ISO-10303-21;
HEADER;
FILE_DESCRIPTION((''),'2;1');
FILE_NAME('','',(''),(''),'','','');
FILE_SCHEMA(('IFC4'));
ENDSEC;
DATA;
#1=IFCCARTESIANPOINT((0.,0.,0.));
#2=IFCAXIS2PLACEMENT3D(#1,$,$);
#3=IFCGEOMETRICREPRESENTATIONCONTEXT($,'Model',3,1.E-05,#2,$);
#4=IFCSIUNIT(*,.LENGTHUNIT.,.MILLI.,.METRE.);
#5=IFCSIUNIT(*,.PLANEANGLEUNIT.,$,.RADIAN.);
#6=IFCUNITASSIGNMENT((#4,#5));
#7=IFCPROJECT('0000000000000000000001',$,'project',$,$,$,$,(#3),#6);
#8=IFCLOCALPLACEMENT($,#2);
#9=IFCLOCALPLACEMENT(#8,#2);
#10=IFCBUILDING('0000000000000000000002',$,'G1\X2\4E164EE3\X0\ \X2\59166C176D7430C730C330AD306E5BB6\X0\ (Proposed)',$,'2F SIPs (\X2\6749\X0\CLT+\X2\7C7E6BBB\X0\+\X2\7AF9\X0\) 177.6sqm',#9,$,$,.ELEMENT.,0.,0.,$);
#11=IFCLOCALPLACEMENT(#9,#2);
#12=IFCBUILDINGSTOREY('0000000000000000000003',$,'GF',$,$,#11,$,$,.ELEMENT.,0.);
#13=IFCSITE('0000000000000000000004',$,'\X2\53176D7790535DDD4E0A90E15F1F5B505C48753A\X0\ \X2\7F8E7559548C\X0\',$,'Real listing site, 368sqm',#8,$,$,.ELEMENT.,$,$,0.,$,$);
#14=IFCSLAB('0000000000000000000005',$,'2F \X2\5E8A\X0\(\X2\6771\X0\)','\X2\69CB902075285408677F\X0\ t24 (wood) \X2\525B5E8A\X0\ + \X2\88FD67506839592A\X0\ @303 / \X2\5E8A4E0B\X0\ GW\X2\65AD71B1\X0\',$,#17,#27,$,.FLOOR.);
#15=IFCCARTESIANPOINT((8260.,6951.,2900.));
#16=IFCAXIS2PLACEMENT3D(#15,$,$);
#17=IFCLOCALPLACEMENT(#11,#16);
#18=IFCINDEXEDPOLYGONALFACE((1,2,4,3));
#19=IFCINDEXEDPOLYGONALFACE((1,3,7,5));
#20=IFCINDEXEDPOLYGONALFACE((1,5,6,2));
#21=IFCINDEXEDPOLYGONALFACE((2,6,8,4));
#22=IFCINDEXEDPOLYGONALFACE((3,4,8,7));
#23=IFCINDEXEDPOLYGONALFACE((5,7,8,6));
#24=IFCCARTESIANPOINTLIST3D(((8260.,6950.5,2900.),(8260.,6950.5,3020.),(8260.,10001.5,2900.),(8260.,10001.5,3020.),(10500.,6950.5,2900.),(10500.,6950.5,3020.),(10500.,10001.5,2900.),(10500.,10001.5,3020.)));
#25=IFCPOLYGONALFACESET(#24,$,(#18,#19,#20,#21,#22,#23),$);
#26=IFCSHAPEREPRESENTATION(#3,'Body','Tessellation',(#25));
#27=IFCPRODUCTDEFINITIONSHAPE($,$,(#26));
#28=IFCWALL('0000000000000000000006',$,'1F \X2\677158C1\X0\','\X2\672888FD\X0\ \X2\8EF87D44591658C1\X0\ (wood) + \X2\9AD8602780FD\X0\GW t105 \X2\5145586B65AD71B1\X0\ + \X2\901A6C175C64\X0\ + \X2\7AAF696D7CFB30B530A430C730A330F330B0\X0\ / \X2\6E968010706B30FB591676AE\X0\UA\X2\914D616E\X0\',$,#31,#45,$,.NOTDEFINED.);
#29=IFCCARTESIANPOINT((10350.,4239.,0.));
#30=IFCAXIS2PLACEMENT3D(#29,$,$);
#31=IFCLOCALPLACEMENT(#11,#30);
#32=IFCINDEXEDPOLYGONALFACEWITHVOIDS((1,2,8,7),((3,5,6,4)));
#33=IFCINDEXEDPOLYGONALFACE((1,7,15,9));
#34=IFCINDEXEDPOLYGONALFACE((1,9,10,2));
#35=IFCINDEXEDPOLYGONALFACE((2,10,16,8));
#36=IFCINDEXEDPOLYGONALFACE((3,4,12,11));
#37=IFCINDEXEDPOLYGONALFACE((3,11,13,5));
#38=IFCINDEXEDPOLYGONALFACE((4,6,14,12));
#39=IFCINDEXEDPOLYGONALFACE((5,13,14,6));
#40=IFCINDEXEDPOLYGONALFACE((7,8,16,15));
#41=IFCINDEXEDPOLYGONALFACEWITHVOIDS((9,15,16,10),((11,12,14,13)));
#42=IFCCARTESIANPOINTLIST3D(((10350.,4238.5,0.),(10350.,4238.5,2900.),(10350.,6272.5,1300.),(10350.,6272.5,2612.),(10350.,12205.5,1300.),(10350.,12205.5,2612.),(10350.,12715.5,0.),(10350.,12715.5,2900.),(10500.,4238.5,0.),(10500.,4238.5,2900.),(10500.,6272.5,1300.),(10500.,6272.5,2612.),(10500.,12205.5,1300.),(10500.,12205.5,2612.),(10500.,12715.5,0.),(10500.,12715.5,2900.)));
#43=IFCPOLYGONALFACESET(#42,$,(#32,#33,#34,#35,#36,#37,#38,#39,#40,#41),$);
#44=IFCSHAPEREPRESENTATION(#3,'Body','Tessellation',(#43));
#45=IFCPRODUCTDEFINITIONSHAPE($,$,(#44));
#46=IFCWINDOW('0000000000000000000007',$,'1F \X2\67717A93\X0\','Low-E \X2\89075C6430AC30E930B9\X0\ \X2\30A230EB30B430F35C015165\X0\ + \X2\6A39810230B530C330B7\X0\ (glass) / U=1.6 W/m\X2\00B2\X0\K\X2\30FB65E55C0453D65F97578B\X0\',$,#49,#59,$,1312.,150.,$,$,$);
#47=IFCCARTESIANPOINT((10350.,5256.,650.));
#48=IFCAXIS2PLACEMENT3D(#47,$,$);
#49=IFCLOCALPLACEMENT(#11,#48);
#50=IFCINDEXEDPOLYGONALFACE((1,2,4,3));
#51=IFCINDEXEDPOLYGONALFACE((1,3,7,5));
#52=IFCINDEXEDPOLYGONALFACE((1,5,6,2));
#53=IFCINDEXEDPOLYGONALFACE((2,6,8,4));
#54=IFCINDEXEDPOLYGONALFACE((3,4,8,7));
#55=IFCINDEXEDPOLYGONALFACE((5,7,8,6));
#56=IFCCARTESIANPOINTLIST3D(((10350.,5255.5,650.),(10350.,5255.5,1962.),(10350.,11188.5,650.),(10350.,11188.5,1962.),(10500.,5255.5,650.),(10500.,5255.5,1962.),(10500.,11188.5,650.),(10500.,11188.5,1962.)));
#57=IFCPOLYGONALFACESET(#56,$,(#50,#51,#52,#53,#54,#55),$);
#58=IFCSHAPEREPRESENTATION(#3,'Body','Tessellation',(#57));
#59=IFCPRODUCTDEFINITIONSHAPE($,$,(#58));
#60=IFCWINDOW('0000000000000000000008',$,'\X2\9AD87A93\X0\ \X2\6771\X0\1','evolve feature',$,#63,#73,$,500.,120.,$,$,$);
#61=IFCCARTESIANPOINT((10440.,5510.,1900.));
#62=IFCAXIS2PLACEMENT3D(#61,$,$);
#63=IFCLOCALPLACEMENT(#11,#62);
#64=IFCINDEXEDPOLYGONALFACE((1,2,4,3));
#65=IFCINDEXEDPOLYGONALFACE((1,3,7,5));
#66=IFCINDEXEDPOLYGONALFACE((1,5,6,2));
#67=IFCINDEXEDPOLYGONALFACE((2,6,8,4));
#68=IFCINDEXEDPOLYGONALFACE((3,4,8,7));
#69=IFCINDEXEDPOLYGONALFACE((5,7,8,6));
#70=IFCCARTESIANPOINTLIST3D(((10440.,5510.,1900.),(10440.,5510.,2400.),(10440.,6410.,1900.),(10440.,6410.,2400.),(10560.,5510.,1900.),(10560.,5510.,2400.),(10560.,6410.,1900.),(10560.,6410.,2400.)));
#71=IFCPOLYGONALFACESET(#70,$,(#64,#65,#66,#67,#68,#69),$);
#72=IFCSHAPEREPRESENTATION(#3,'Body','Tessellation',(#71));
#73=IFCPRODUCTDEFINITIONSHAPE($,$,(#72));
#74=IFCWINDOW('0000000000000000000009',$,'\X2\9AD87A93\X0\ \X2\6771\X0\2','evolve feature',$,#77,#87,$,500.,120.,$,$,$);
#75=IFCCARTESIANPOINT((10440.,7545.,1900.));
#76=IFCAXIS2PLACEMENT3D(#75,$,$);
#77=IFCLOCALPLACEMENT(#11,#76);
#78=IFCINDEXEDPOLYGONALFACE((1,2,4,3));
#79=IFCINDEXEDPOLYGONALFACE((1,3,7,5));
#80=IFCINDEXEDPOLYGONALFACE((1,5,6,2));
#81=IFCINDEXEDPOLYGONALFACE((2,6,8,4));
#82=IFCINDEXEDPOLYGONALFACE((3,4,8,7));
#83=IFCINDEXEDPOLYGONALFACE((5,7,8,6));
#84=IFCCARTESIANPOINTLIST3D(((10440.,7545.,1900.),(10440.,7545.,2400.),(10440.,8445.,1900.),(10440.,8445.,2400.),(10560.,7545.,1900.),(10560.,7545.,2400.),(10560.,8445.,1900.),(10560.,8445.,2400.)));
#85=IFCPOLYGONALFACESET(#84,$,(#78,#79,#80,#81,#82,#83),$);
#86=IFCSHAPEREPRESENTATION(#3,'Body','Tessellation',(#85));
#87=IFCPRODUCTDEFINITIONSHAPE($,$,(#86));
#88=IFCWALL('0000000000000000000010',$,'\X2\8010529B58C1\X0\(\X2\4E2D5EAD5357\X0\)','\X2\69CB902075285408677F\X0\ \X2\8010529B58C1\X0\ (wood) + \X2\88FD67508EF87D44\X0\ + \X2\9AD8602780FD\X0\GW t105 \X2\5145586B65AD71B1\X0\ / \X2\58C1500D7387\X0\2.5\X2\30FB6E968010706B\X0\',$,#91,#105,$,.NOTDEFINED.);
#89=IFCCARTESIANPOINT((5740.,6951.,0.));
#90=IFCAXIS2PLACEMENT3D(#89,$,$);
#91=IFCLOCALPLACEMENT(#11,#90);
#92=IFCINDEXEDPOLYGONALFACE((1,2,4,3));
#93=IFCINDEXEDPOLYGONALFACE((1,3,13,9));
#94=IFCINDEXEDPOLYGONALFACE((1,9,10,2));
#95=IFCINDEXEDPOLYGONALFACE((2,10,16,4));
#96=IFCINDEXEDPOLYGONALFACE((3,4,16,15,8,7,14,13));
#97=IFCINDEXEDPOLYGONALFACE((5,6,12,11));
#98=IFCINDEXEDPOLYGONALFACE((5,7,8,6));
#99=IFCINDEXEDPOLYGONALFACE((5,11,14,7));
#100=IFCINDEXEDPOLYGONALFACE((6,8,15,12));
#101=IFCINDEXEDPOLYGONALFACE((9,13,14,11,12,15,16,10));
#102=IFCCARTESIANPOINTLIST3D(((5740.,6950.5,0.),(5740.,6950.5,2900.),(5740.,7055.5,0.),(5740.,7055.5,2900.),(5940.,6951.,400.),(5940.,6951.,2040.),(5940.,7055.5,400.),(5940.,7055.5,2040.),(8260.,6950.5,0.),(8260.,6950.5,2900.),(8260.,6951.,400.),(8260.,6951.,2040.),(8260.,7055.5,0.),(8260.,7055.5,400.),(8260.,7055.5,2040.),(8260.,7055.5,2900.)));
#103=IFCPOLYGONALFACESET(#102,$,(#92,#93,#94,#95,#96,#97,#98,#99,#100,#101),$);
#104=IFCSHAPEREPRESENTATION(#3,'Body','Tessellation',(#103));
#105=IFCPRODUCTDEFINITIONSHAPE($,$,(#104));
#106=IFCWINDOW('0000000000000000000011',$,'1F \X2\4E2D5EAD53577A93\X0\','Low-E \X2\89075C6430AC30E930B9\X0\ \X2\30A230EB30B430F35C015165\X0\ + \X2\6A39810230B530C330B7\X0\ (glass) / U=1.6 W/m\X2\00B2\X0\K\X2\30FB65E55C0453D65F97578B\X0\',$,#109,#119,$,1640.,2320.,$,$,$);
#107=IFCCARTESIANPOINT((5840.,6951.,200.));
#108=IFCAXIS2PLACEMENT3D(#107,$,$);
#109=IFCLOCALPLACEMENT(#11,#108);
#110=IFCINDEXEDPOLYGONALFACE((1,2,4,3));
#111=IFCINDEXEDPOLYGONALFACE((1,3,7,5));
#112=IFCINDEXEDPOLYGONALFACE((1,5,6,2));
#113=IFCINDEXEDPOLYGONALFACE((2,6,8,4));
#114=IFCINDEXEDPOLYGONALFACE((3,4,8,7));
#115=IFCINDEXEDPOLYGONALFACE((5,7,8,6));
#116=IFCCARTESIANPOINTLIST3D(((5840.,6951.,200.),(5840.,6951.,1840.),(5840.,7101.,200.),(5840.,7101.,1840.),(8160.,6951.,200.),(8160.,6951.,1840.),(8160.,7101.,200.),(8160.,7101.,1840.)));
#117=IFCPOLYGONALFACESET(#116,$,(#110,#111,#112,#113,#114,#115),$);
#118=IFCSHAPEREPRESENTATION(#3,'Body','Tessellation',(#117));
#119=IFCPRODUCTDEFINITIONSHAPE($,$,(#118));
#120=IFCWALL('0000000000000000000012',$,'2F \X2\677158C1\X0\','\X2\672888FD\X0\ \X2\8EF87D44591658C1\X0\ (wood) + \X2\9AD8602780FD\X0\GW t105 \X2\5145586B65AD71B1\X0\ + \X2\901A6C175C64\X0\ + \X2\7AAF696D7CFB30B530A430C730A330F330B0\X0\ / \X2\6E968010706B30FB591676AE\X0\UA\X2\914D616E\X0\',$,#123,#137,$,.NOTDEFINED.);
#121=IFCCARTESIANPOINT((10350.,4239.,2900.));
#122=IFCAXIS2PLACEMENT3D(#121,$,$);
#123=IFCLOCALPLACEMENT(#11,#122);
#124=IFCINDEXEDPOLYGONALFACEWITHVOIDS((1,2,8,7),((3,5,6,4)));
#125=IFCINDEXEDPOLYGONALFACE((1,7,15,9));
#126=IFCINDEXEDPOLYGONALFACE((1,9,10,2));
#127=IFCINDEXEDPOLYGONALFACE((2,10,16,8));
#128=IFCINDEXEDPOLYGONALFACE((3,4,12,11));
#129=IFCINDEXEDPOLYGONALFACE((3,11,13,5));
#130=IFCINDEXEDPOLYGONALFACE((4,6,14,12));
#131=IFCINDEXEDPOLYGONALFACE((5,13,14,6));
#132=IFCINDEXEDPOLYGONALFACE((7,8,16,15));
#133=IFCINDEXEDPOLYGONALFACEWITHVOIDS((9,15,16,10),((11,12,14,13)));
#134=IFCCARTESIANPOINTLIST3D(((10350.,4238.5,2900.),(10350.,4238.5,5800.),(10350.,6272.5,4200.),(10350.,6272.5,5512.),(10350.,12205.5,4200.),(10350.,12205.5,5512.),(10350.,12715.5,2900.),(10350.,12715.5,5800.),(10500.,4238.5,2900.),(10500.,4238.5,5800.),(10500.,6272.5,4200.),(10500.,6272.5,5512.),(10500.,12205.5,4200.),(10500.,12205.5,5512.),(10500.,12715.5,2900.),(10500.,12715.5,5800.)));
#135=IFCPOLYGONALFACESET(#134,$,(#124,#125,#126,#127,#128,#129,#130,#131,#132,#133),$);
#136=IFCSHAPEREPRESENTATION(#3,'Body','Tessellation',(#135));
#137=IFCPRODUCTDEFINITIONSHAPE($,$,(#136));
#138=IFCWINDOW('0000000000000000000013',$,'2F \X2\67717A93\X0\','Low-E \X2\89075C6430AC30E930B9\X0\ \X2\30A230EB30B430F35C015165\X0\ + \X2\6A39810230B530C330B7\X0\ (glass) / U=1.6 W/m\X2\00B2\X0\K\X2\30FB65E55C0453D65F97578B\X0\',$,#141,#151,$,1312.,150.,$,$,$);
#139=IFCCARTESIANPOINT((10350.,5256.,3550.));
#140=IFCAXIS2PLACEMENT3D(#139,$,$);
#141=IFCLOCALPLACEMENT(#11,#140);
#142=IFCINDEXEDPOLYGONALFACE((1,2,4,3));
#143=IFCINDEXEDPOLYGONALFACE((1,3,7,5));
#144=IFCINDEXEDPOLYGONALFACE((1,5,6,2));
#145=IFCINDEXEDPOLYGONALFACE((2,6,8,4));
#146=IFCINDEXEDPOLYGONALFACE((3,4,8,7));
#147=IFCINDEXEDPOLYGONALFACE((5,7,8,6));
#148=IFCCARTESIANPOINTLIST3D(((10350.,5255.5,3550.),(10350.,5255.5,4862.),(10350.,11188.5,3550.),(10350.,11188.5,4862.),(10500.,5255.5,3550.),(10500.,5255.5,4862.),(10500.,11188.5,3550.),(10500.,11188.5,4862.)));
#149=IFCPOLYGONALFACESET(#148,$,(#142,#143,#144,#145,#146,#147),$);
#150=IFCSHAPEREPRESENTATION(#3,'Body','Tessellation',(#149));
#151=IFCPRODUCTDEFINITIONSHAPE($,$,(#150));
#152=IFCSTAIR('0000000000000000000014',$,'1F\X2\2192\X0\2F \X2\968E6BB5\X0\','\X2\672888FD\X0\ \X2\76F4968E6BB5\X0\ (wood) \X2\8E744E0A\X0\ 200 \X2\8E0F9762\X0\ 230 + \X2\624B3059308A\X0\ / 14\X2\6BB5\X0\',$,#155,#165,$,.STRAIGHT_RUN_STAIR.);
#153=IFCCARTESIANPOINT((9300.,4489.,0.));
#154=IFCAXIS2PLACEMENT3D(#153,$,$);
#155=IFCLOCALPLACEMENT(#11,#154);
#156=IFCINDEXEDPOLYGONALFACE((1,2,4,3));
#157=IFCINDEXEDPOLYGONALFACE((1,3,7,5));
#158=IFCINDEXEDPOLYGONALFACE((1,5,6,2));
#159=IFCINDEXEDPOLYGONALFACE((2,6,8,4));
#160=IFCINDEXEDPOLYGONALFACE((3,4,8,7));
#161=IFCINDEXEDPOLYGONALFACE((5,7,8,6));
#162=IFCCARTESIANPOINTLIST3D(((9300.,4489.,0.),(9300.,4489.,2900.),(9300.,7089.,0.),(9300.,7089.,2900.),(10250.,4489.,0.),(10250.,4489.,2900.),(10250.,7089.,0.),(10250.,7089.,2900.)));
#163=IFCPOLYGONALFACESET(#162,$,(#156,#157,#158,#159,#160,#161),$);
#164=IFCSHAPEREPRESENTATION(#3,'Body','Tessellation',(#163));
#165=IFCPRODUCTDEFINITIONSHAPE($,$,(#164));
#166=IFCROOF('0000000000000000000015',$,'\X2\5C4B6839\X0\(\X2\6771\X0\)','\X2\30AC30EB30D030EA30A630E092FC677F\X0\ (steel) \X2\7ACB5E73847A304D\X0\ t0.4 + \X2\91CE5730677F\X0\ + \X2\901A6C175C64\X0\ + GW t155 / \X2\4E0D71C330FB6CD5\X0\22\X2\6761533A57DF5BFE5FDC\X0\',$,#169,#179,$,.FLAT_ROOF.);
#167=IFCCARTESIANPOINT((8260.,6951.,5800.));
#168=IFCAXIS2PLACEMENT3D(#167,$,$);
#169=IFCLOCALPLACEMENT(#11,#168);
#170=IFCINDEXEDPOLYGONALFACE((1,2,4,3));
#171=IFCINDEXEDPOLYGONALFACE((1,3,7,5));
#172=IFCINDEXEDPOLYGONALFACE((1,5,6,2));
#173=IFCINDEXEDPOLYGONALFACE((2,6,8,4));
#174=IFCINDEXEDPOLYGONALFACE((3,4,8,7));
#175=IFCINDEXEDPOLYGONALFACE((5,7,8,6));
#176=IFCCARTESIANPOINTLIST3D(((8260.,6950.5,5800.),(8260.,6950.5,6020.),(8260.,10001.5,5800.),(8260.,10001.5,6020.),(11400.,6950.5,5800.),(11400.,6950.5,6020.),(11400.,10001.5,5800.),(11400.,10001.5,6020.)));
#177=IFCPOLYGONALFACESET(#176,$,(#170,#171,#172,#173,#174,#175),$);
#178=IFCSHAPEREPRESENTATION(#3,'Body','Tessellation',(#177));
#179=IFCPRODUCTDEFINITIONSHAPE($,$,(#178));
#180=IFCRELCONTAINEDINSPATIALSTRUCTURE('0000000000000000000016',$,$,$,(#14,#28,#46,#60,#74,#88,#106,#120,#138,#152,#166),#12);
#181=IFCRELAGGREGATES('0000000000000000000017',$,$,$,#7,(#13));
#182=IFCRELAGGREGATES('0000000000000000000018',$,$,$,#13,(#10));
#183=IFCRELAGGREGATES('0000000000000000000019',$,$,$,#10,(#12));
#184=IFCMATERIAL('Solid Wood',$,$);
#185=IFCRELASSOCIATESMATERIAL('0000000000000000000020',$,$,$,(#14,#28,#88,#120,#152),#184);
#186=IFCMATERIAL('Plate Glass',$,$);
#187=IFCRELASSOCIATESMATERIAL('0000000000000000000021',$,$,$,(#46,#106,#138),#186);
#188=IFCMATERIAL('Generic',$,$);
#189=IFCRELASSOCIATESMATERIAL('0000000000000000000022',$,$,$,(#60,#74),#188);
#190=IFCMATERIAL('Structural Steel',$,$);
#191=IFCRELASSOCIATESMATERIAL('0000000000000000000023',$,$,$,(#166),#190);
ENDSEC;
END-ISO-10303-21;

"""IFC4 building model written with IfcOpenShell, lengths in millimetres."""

from ifc_helpers import new_model, si_unit, frame, frame_2d, origin, place, context, project, spatial, rectangle, extrude, material, element, fill, save


model = new_model("IFC4")

# Units and contexts
model_context = context("Model", 3, precision=1e-05, world=origin())
ifc_project = project(units=[si_unit("LENGTHUNIT", "METRE", prefix="MILLI"), si_unit("PLANEANGLEUNIT", "RADIAN")], contexts=[model_context])

# Site, building, storey
site_placement = place(None, origin())
site = spatial("IfcSite", under=ifc_project, at=site_placement, Name="北海道川上郡弟子屈町 美留和", ObjectType="Real listing site, 368sqm", CompositionType="ELEMENT", RefElevation=0.0)
building_placement = place(site_placement, origin())
building = spatial("IfcBuilding", under=site, at=building_placement, Name="G1世代 外気浴デッキの家 (Proposed)", ObjectType="2F SIPs (杉CLT+籾殻+竹) 177.6sqm", CompositionType="ELEMENT", ElevationOfRefHeight=0.0, ElevationOfTerrain=0.0)
storey_placement = place(building_placement, origin())
storey = spatial("IfcBuildingStorey", under=building, at=storey_placement, Name="GF", CompositionType="ELEMENT", Elevation=0.0)

# Slab
ifc_material_1 = material(Name="Solid Wood")
slab_1_placement = place(storey_placement, frame((8260.0, 6951.0, 2900.0)))
element("IfcSlab", 1, at=slab_1_placement, inside=storey, material=ifc_material_1, Name="2F 床(東)", Description="構造用合板 t24 (wood) 剛床 + 製材根太 @303 / 床下 GW断熱", PredefinedType="FLOOR", context=model_context, shape_type="SweptSolid", body=[
    extrude(rectangle(XDim=2240.0, YDim=3051.0, at=frame_2d((1120.0, 1525.0))), frame((8260.0, 6951.0, 2900.0)), (0.0, 0.0, 1.0), 120.0),
])

# Wall, openings, windows
wall_1_placement = place(storey_placement, frame((10350.0, 4239.0, 0.0)))
wall_1 = element("IfcWall", 2, at=wall_1_placement, inside=storey, material=ifc_material_1, Name="1F 東壁", Description="木製 軸組外壁 (wood) + 高性能GW t105 充填断熱 + 通気層 + 窯業系サイディング / 準耐火・外皮UA配慮", PredefinedType="NOTDEFINED", context=model_context, shape_type="SweptSolid", body=[
    extrude(rectangle(XDim=150.0, YDim=8477.0, at=frame_2d((75.0, 4238.0))), frame((10350.0, 4239.0, 0.0)), (0.0, 0.0, 1.0), 2900.0),
])
opening_1_placement = place(storey_placement, frame((10350.0, 5256.0, 650.0)))
opening_1 = element("IfcOpeningElement", 3, at=opening_1_placement, cuts=wall_1, PredefinedType="NOTDEFINED", context=model_context, shape_type="SweptSolid", body=[
    extrude(rectangle(XDim=150.0, YDim=5933.0, at=frame_2d((75.0, 2966.0))), frame((10350.0, 5256.0, 650.0)), (0.0, 0.0, 1.0), 1312.0),
])
opening_2_placement = place(storey_placement, frame((10440.0, 5510.0, 1900.0)))
opening_2 = element("IfcOpeningElement", 4, at=opening_2_placement, cuts=wall_1, PredefinedType="NOTDEFINED", context=model_context, shape_type="SweptSolid", body=[
    extrude(rectangle(XDim=120.0, YDim=900.0, at=frame_2d((60.0, 450.0))), frame((10440.0, 5510.0, 1900.0)), (0.0, 0.0, 1.0), 500.0),
])
opening_3_placement = place(storey_placement, frame((10440.0, 7545.0, 1900.0)))
opening_3 = element("IfcOpeningElement", 5, at=opening_3_placement, cuts=wall_1, PredefinedType="NOTDEFINED", context=model_context, shape_type="SweptSolid", body=[
    extrude(rectangle(XDim=120.0, YDim=900.0, at=frame_2d((60.0, 450.0))), frame((10440.0, 7545.0, 1900.0)), (0.0, 0.0, 1.0), 500.0),
])
ifc_material_2 = material(Name="Plate Glass")
window_1_placement = place(storey_placement, frame((10350.0, 5256.0, 650.0)))
window_1 = element("IfcWindow", 6, at=window_1_placement, inside=storey, material=ifc_material_2, Name="1F 東窓", Description="Low-E 複層ガラス アルゴン封入 + 樹脂サッシ (glass) / U=1.6 W/m²K・日射取得型", OverallHeight=1312.0, OverallWidth=150.0, context=model_context, shape_type="SweptSolid", body=[
    extrude(rectangle(XDim=150.0, YDim=5933.0, at=frame_2d((75.0, 2966.0))), frame((10350.0, 5256.0, 650.0)), (0.0, 0.0, 1.0), 1312.0),
])
fill(opening_1, window_1)
ifc_material_3 = material(Name="Generic")
window_2_placement = place(storey_placement, frame((10440.0, 5510.0, 1900.0)))
window_2 = element("IfcWindow", 7, at=window_2_placement, inside=storey, material=ifc_material_3, Name="高窓 東1", Description="evolve feature", OverallHeight=500.0, OverallWidth=120.0, context=model_context, shape_type="SweptSolid", body=[
    extrude(rectangle(XDim=120.0, YDim=900.0, at=frame_2d((60.0, 450.0))), frame((10440.0, 5510.0, 1900.0)), (0.0, 0.0, 1.0), 500.0),
])
fill(opening_2, window_2)
window_3_placement = place(storey_placement, frame((10440.0, 7545.0, 1900.0)))
window_3 = element("IfcWindow", 8, at=window_3_placement, inside=storey, material=ifc_material_3, Name="高窓 東2", Description="evolve feature", OverallHeight=500.0, OverallWidth=120.0, context=model_context, shape_type="SweptSolid", body=[
    extrude(rectangle(XDim=120.0, YDim=900.0, at=frame_2d((60.0, 450.0))), frame((10440.0, 7545.0, 1900.0)), (0.0, 0.0, 1.0), 500.0),
])
fill(opening_3, window_3)

# Wall, opening, window
wall_2_placement = place(storey_placement, frame((5740.0, 6951.0, 0.0)))
wall_2 = element("IfcWall", 9, at=wall_2_placement, inside=storey, material=ifc_material_1, Name="耐力壁(中庭南)", Description="構造用合板 耐力壁 (wood) + 製材軸組 + 高性能GW t105 充填断熱 / 壁倍率2.5・準耐火", PredefinedType="NOTDEFINED", context=model_context, shape_type="SweptSolid", body=[
    extrude(rectangle(XDim=2520.0, YDim=105.0, at=frame_2d((1260.0, 52.0))), frame((5740.0, 6951.0, 0.0)), (0.0, 0.0, 1.0), 2900.0),
])
opening_4_placement = place(storey_placement, frame((5840.0, 6951.0, 200.0)))
opening_4 = element("IfcOpeningElement", 10, at=opening_4_placement, cuts=wall_2, PredefinedType="NOTDEFINED", context=model_context, shape_type="SweptSolid", body=[
    extrude(rectangle(XDim=2320.0, YDim=150.0, at=frame_2d((1160.0, 75.0))), frame((5840.0, 6951.0, 200.0)), (0.0, 0.0, 1.0), 1640.0),
])
window_4_placement = place(storey_placement, frame((5840.0, 6951.0, 200.0)))
window_4 = element("IfcWindow", 11, at=window_4_placement, inside=storey, material=ifc_material_2, Name="1F 中庭南窓", Description="Low-E 複層ガラス アルゴン封入 + 樹脂サッシ (glass) / U=1.6 W/m²K・日射取得型", OverallHeight=1640.0, OverallWidth=2320.0, context=model_context, shape_type="SweptSolid", body=[
    extrude(rectangle(XDim=2320.0, YDim=150.0, at=frame_2d((1160.0, 75.0))), frame((5840.0, 6951.0, 200.0)), (0.0, 0.0, 1.0), 1640.0),
])
fill(opening_4, window_4)

# Wall, opening, window
wall_3_placement = place(storey_placement, frame((10350.0, 4239.0, 2900.0)))
wall_3 = element("IfcWall", 12, at=wall_3_placement, inside=storey, material=ifc_material_1, Name="2F 東壁", Description="木製 軸組外壁 (wood) + 高性能GW t105 充填断熱 + 通気層 + 窯業系サイディング / 準耐火・外皮UA配慮", PredefinedType="NOTDEFINED", context=model_context, shape_type="SweptSolid", body=[
    extrude(rectangle(XDim=150.0, YDim=8477.0, at=frame_2d((75.0, 4238.0))), frame((10350.0, 4239.0, 2900.0)), (0.0, 0.0, 1.0), 2900.0),
])
opening_5_placement = place(storey_placement, frame((10350.0, 5256.0, 3550.0)))
opening_5 = element("IfcOpeningElement", 13, at=opening_5_placement, cuts=wall_3, PredefinedType="NOTDEFINED", context=model_context, shape_type="SweptSolid", body=[
    extrude(rectangle(XDim=150.0, YDim=5933.0, at=frame_2d((75.0, 2966.0))), frame((10350.0, 5256.0, 3550.0)), (0.0, 0.0, 1.0), 1312.0),
])
window_5_placement = place(storey_placement, frame((10350.0, 5256.0, 3550.0)))
window_5 = element("IfcWindow", 14, at=window_5_placement, inside=storey, material=ifc_material_2, Name="2F 東窓", Description="Low-E 複層ガラス アルゴン封入 + 樹脂サッシ (glass) / U=1.6 W/m²K・日射取得型", OverallHeight=1312.0, OverallWidth=150.0, context=model_context, shape_type="SweptSolid", body=[
    extrude(rectangle(XDim=150.0, YDim=5933.0, at=frame_2d((75.0, 2966.0))), frame((10350.0, 5256.0, 3550.0)), (0.0, 0.0, 1.0), 1312.0),
])
fill(opening_5, window_5)

# Stair
stair_placement = place(storey_placement, frame((9300.0, 4489.0, 0.0)))
element("IfcStair", 15, at=stair_placement, inside=storey, material=ifc_material_1, Name="1F→2F 階段", Description="木製 直階段 (wood) 蹴上 200 踏面 230 + 手すり / 14段", PredefinedType="STRAIGHT_RUN_STAIR", context=model_context, shape_type="SweptSolid", body=[
    extrude(rectangle(XDim=950.0, YDim=2600.0, at=frame_2d((475.0, 1300.0))), frame((9300.0, 4489.0, 0.0)), (0.0, 0.0, 1.0), 2900.0),
])

# Roof
ifc_material_4 = material(Name="Structural Steel")
roof_placement = place(storey_placement, frame((8260.0, 6951.0, 5800.0)))
element("IfcRoof", 16, at=roof_placement, inside=storey, material=ifc_material_4, Name="屋根(東)", Description="ガルバリウム鋼板 (steel) 立平葺き t0.4 + 野地板 + 通気層 + GW t155 / 不燃・法22条区域対応", PredefinedType="FLAT_ROOF", context=model_context, shape_type="SweptSolid", body=[
    extrude(rectangle(XDim=3140.0, YDim=3051.0, at=frame_2d((1570.0, 1525.0))), frame((8260.0, 6951.0, 5800.0)), (0.0, 0.0, 1.0), 220.0),
])

save(model, "model.ifc")
